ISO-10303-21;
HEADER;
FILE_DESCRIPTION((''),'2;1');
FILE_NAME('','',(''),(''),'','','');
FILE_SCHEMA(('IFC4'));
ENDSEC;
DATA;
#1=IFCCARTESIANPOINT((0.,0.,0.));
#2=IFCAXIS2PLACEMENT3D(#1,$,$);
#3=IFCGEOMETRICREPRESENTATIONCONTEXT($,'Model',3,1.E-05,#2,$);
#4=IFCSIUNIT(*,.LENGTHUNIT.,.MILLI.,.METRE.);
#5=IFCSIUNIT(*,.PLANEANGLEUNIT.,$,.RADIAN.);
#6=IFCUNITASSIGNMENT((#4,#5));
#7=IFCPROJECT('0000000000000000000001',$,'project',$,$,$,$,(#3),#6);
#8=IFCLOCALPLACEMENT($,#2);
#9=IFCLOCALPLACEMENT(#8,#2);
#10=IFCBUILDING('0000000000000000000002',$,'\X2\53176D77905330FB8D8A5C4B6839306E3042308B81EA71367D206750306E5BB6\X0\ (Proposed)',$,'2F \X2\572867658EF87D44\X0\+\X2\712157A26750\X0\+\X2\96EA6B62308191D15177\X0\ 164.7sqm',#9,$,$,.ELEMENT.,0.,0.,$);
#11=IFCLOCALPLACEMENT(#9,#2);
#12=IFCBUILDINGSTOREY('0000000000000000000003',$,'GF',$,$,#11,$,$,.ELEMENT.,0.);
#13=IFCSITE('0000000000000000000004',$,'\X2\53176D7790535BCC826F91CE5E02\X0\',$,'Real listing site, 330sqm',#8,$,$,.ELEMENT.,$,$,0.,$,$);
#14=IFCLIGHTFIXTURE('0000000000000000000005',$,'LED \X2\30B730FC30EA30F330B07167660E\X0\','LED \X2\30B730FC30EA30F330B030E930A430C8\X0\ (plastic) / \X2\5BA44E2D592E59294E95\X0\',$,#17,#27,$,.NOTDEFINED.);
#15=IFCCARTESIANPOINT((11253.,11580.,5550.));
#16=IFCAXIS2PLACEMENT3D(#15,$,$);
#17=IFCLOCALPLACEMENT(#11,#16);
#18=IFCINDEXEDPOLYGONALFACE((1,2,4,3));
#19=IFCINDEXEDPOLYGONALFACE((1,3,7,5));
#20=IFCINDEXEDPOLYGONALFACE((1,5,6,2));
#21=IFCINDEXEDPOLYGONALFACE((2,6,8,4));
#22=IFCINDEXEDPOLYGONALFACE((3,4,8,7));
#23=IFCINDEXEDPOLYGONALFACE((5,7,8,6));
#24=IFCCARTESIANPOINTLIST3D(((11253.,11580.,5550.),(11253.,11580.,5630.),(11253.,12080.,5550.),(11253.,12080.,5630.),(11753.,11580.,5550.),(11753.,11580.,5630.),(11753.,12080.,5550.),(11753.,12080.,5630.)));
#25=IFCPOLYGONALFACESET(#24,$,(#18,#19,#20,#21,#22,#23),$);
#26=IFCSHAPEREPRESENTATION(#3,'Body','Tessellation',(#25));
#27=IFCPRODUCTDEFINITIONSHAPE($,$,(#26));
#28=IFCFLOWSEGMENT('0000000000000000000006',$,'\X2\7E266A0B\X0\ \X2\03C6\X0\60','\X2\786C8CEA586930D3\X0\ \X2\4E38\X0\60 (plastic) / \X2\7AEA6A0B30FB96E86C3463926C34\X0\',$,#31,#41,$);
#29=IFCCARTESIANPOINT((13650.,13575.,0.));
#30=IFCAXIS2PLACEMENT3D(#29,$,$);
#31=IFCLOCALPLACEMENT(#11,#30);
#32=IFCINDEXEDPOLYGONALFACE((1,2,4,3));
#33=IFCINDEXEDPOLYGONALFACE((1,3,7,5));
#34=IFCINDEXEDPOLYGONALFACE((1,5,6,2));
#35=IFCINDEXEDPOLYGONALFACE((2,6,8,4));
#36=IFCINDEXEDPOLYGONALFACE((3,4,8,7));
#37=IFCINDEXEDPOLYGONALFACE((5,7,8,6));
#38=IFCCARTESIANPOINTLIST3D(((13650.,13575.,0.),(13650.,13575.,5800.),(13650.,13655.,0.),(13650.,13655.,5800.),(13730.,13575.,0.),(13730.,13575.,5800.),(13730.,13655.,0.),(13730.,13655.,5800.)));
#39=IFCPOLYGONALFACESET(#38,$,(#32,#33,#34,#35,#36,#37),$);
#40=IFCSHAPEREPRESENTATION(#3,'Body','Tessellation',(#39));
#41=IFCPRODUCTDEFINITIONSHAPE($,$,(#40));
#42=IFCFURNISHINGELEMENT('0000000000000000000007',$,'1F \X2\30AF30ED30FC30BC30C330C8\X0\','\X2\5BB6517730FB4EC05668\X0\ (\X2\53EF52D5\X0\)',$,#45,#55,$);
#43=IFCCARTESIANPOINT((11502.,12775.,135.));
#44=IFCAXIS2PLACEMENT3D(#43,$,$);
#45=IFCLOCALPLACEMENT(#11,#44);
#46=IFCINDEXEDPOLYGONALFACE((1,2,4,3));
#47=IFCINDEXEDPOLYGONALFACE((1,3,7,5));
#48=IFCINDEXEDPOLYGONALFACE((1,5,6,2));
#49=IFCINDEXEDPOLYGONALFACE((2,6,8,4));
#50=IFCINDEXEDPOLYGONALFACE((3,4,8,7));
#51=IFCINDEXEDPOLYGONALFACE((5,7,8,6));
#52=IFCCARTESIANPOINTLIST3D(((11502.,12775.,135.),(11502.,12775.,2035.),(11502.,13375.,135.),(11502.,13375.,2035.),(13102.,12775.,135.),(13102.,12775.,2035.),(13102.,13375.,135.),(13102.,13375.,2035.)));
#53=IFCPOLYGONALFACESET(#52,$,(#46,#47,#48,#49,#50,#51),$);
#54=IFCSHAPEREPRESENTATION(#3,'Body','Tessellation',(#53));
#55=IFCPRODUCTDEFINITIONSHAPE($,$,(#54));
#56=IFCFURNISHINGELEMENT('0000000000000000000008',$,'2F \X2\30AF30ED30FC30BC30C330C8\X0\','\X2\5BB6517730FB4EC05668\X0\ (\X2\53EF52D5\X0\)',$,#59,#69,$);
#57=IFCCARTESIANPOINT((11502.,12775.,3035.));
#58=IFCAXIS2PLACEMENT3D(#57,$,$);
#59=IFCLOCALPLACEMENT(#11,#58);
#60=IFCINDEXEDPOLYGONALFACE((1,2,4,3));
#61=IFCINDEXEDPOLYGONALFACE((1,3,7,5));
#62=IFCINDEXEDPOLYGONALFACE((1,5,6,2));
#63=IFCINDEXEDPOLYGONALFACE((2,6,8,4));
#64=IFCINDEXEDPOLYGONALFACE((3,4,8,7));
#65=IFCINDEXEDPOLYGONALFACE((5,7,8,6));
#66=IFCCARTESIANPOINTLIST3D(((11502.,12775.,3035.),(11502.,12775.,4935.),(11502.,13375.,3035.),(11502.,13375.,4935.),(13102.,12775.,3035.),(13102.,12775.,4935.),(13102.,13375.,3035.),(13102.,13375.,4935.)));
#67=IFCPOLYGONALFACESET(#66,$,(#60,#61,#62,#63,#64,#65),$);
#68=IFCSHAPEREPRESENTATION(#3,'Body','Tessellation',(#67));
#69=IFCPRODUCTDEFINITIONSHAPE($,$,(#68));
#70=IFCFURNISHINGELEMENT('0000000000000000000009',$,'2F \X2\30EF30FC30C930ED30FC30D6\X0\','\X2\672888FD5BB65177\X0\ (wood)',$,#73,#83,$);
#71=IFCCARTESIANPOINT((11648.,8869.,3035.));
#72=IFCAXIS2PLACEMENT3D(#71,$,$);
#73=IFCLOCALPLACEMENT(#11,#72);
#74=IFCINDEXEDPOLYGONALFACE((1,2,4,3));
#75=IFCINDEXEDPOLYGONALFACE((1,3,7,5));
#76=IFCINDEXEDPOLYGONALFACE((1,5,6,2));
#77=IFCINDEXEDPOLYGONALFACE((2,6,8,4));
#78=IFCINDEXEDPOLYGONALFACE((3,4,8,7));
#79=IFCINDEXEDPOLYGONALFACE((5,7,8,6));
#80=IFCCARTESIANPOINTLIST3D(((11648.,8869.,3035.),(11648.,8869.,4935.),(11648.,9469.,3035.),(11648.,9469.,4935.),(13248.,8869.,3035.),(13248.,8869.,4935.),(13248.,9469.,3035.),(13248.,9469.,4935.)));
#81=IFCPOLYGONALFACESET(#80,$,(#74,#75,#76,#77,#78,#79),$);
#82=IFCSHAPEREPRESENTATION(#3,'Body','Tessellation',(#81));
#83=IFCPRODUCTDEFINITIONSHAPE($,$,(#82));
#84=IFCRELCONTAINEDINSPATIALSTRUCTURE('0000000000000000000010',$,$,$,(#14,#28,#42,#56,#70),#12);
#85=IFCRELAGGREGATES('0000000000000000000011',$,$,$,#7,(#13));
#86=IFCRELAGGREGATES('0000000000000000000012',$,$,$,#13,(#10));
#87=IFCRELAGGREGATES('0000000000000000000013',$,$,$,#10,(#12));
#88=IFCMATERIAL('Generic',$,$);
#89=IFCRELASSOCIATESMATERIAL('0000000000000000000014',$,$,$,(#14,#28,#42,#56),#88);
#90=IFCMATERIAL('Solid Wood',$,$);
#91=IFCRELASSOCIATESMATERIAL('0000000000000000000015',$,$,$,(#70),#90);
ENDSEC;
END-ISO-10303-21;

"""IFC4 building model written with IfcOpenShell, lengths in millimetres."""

from ifc_helpers import new_model, si_unit, frame, frame_2d, origin, place, context, project, spatial, rectangle, extrude, material, element, save


model = new_model("IFC4")

# Units and contexts
model_context = context("Model", 3, precision=1e-05, world=origin())
ifc_project = project(units=[si_unit("LENGTHUNIT", "METRE", prefix="MILLI"), si_unit("PLANEANGLEUNIT", "RADIAN")], contexts=[model_context])

# Site, building, storey
site_placement = place(None, origin())
site = spatial("IfcSite", under=ifc_project, at=site_placement, Name="北海道富良野市", ObjectType="Real listing site, 330sqm", CompositionType="ELEMENT", RefElevation=0.0)
building_placement = place(site_placement, origin())
building = spatial("IfcBuilding", under=site, at=building_placement, Name="北海道・越屋根のある自然素材の家 (Proposed)", ObjectType="2F 在来軸組+無垢材+雪止め金具 164.7sqm", CompositionType="ELEMENT", ElevationOfRefHeight=0.0, ElevationOfTerrain=0.0)
storey_placement = place(building_placement, origin())
storey = spatial("IfcBuildingStorey", under=building, at=storey_placement, Name="GF", CompositionType="ELEMENT", Elevation=0.0)

# Shared definitions
ifc_material_1 = material(Name="Solid Wood")

# Shared definitions
ifc_material_2 = material(Name="Generic")

# Light fixture
light_fixture_1_placement = place(storey_placement, frame((11253.0, 11580.0, 5550.0)))
element("IfcLightFixture", 1, at=light_fixture_1_placement, inside=storey, material=ifc_material_2, Name="LED シーリング照明", Description="LED シーリングライト (plastic) / 室中央天井", PredefinedType="NOTDEFINED", context=model_context, shape_type="SweptSolid", body=[
    extrude(rectangle(XDim=500.0, YDim=500.0, at=frame_2d((250.0, 250.0))), frame((11253.0, 11580.0, 5550.0)), (0.0, 0.0, 1.0), 80.0),
])

# Flow segment
flow_segment_placement = place(storey_placement, frame((13650.0, 13575.0, 0.0)))
element("IfcFlowSegment", 2, at=flow_segment_placement, inside=storey, material=ifc_material_2, Name="縦樋 φ60", Description="硬質塩ビ 丸60 (plastic) / 竪樋・雨水排水", context=model_context, shape_type="SweptSolid", body=[
    extrude(rectangle(XDim=80.0, YDim=80.0, at=frame_2d((40.0, 40.0))), frame((13650.0, 13575.0, 0.0)), (0.0, 0.0, 1.0), 5800.0),
])

# Furnishing elements
furnishing_1_placement = place(storey_placement, frame((11502.0, 12775.0, 135.0)))
element("IfcFurnishingElement", 3, at=furnishing_1_placement, inside=storey, material=ifc_material_2, Name="1F クローゼット", Description="家具・什器 (可動)", context=model_context, shape_type="SweptSolid", body=[
    extrude(rectangle(XDim=1600.0, YDim=600.0, at=frame_2d((800.0, 300.0))), frame((11502.0, 12775.0, 135.0)), (0.0, 0.0, 1.0), 1900.0),
])
furnishing_2_placement = place(storey_placement, frame((11502.0, 12775.0, 3035.0)))
element("IfcFurnishingElement", 4, at=furnishing_2_placement, inside=storey, material=ifc_material_2, Name="2F クローゼット", Description="家具・什器 (可動)", context=model_context, shape_type="SweptSolid", body=[
    extrude(rectangle(XDim=1600.0, YDim=600.0, at=frame_2d((800.0, 300.0))), frame((11502.0, 12775.0, 3035.0)), (0.0, 0.0, 1.0), 1900.0),
])
furnishing_3_placement = place(storey_placement, frame((11648.0, 8869.0, 3035.0)))
element("IfcFurnishingElement", 5, at=furnishing_3_placement, inside=storey, material=ifc_material_1, Name="2F ワードローブ", Description="木製家具 (wood)", context=model_context, shape_type="SweptSolid", body=[
    extrude(rectangle(XDim=1600.0, YDim=600.0, at=frame_2d((800.0, 300.0))), frame((11648.0, 8869.0, 3035.0)), (0.0, 0.0, 1.0), 1900.0),
])

save(model, "model.ifc")
